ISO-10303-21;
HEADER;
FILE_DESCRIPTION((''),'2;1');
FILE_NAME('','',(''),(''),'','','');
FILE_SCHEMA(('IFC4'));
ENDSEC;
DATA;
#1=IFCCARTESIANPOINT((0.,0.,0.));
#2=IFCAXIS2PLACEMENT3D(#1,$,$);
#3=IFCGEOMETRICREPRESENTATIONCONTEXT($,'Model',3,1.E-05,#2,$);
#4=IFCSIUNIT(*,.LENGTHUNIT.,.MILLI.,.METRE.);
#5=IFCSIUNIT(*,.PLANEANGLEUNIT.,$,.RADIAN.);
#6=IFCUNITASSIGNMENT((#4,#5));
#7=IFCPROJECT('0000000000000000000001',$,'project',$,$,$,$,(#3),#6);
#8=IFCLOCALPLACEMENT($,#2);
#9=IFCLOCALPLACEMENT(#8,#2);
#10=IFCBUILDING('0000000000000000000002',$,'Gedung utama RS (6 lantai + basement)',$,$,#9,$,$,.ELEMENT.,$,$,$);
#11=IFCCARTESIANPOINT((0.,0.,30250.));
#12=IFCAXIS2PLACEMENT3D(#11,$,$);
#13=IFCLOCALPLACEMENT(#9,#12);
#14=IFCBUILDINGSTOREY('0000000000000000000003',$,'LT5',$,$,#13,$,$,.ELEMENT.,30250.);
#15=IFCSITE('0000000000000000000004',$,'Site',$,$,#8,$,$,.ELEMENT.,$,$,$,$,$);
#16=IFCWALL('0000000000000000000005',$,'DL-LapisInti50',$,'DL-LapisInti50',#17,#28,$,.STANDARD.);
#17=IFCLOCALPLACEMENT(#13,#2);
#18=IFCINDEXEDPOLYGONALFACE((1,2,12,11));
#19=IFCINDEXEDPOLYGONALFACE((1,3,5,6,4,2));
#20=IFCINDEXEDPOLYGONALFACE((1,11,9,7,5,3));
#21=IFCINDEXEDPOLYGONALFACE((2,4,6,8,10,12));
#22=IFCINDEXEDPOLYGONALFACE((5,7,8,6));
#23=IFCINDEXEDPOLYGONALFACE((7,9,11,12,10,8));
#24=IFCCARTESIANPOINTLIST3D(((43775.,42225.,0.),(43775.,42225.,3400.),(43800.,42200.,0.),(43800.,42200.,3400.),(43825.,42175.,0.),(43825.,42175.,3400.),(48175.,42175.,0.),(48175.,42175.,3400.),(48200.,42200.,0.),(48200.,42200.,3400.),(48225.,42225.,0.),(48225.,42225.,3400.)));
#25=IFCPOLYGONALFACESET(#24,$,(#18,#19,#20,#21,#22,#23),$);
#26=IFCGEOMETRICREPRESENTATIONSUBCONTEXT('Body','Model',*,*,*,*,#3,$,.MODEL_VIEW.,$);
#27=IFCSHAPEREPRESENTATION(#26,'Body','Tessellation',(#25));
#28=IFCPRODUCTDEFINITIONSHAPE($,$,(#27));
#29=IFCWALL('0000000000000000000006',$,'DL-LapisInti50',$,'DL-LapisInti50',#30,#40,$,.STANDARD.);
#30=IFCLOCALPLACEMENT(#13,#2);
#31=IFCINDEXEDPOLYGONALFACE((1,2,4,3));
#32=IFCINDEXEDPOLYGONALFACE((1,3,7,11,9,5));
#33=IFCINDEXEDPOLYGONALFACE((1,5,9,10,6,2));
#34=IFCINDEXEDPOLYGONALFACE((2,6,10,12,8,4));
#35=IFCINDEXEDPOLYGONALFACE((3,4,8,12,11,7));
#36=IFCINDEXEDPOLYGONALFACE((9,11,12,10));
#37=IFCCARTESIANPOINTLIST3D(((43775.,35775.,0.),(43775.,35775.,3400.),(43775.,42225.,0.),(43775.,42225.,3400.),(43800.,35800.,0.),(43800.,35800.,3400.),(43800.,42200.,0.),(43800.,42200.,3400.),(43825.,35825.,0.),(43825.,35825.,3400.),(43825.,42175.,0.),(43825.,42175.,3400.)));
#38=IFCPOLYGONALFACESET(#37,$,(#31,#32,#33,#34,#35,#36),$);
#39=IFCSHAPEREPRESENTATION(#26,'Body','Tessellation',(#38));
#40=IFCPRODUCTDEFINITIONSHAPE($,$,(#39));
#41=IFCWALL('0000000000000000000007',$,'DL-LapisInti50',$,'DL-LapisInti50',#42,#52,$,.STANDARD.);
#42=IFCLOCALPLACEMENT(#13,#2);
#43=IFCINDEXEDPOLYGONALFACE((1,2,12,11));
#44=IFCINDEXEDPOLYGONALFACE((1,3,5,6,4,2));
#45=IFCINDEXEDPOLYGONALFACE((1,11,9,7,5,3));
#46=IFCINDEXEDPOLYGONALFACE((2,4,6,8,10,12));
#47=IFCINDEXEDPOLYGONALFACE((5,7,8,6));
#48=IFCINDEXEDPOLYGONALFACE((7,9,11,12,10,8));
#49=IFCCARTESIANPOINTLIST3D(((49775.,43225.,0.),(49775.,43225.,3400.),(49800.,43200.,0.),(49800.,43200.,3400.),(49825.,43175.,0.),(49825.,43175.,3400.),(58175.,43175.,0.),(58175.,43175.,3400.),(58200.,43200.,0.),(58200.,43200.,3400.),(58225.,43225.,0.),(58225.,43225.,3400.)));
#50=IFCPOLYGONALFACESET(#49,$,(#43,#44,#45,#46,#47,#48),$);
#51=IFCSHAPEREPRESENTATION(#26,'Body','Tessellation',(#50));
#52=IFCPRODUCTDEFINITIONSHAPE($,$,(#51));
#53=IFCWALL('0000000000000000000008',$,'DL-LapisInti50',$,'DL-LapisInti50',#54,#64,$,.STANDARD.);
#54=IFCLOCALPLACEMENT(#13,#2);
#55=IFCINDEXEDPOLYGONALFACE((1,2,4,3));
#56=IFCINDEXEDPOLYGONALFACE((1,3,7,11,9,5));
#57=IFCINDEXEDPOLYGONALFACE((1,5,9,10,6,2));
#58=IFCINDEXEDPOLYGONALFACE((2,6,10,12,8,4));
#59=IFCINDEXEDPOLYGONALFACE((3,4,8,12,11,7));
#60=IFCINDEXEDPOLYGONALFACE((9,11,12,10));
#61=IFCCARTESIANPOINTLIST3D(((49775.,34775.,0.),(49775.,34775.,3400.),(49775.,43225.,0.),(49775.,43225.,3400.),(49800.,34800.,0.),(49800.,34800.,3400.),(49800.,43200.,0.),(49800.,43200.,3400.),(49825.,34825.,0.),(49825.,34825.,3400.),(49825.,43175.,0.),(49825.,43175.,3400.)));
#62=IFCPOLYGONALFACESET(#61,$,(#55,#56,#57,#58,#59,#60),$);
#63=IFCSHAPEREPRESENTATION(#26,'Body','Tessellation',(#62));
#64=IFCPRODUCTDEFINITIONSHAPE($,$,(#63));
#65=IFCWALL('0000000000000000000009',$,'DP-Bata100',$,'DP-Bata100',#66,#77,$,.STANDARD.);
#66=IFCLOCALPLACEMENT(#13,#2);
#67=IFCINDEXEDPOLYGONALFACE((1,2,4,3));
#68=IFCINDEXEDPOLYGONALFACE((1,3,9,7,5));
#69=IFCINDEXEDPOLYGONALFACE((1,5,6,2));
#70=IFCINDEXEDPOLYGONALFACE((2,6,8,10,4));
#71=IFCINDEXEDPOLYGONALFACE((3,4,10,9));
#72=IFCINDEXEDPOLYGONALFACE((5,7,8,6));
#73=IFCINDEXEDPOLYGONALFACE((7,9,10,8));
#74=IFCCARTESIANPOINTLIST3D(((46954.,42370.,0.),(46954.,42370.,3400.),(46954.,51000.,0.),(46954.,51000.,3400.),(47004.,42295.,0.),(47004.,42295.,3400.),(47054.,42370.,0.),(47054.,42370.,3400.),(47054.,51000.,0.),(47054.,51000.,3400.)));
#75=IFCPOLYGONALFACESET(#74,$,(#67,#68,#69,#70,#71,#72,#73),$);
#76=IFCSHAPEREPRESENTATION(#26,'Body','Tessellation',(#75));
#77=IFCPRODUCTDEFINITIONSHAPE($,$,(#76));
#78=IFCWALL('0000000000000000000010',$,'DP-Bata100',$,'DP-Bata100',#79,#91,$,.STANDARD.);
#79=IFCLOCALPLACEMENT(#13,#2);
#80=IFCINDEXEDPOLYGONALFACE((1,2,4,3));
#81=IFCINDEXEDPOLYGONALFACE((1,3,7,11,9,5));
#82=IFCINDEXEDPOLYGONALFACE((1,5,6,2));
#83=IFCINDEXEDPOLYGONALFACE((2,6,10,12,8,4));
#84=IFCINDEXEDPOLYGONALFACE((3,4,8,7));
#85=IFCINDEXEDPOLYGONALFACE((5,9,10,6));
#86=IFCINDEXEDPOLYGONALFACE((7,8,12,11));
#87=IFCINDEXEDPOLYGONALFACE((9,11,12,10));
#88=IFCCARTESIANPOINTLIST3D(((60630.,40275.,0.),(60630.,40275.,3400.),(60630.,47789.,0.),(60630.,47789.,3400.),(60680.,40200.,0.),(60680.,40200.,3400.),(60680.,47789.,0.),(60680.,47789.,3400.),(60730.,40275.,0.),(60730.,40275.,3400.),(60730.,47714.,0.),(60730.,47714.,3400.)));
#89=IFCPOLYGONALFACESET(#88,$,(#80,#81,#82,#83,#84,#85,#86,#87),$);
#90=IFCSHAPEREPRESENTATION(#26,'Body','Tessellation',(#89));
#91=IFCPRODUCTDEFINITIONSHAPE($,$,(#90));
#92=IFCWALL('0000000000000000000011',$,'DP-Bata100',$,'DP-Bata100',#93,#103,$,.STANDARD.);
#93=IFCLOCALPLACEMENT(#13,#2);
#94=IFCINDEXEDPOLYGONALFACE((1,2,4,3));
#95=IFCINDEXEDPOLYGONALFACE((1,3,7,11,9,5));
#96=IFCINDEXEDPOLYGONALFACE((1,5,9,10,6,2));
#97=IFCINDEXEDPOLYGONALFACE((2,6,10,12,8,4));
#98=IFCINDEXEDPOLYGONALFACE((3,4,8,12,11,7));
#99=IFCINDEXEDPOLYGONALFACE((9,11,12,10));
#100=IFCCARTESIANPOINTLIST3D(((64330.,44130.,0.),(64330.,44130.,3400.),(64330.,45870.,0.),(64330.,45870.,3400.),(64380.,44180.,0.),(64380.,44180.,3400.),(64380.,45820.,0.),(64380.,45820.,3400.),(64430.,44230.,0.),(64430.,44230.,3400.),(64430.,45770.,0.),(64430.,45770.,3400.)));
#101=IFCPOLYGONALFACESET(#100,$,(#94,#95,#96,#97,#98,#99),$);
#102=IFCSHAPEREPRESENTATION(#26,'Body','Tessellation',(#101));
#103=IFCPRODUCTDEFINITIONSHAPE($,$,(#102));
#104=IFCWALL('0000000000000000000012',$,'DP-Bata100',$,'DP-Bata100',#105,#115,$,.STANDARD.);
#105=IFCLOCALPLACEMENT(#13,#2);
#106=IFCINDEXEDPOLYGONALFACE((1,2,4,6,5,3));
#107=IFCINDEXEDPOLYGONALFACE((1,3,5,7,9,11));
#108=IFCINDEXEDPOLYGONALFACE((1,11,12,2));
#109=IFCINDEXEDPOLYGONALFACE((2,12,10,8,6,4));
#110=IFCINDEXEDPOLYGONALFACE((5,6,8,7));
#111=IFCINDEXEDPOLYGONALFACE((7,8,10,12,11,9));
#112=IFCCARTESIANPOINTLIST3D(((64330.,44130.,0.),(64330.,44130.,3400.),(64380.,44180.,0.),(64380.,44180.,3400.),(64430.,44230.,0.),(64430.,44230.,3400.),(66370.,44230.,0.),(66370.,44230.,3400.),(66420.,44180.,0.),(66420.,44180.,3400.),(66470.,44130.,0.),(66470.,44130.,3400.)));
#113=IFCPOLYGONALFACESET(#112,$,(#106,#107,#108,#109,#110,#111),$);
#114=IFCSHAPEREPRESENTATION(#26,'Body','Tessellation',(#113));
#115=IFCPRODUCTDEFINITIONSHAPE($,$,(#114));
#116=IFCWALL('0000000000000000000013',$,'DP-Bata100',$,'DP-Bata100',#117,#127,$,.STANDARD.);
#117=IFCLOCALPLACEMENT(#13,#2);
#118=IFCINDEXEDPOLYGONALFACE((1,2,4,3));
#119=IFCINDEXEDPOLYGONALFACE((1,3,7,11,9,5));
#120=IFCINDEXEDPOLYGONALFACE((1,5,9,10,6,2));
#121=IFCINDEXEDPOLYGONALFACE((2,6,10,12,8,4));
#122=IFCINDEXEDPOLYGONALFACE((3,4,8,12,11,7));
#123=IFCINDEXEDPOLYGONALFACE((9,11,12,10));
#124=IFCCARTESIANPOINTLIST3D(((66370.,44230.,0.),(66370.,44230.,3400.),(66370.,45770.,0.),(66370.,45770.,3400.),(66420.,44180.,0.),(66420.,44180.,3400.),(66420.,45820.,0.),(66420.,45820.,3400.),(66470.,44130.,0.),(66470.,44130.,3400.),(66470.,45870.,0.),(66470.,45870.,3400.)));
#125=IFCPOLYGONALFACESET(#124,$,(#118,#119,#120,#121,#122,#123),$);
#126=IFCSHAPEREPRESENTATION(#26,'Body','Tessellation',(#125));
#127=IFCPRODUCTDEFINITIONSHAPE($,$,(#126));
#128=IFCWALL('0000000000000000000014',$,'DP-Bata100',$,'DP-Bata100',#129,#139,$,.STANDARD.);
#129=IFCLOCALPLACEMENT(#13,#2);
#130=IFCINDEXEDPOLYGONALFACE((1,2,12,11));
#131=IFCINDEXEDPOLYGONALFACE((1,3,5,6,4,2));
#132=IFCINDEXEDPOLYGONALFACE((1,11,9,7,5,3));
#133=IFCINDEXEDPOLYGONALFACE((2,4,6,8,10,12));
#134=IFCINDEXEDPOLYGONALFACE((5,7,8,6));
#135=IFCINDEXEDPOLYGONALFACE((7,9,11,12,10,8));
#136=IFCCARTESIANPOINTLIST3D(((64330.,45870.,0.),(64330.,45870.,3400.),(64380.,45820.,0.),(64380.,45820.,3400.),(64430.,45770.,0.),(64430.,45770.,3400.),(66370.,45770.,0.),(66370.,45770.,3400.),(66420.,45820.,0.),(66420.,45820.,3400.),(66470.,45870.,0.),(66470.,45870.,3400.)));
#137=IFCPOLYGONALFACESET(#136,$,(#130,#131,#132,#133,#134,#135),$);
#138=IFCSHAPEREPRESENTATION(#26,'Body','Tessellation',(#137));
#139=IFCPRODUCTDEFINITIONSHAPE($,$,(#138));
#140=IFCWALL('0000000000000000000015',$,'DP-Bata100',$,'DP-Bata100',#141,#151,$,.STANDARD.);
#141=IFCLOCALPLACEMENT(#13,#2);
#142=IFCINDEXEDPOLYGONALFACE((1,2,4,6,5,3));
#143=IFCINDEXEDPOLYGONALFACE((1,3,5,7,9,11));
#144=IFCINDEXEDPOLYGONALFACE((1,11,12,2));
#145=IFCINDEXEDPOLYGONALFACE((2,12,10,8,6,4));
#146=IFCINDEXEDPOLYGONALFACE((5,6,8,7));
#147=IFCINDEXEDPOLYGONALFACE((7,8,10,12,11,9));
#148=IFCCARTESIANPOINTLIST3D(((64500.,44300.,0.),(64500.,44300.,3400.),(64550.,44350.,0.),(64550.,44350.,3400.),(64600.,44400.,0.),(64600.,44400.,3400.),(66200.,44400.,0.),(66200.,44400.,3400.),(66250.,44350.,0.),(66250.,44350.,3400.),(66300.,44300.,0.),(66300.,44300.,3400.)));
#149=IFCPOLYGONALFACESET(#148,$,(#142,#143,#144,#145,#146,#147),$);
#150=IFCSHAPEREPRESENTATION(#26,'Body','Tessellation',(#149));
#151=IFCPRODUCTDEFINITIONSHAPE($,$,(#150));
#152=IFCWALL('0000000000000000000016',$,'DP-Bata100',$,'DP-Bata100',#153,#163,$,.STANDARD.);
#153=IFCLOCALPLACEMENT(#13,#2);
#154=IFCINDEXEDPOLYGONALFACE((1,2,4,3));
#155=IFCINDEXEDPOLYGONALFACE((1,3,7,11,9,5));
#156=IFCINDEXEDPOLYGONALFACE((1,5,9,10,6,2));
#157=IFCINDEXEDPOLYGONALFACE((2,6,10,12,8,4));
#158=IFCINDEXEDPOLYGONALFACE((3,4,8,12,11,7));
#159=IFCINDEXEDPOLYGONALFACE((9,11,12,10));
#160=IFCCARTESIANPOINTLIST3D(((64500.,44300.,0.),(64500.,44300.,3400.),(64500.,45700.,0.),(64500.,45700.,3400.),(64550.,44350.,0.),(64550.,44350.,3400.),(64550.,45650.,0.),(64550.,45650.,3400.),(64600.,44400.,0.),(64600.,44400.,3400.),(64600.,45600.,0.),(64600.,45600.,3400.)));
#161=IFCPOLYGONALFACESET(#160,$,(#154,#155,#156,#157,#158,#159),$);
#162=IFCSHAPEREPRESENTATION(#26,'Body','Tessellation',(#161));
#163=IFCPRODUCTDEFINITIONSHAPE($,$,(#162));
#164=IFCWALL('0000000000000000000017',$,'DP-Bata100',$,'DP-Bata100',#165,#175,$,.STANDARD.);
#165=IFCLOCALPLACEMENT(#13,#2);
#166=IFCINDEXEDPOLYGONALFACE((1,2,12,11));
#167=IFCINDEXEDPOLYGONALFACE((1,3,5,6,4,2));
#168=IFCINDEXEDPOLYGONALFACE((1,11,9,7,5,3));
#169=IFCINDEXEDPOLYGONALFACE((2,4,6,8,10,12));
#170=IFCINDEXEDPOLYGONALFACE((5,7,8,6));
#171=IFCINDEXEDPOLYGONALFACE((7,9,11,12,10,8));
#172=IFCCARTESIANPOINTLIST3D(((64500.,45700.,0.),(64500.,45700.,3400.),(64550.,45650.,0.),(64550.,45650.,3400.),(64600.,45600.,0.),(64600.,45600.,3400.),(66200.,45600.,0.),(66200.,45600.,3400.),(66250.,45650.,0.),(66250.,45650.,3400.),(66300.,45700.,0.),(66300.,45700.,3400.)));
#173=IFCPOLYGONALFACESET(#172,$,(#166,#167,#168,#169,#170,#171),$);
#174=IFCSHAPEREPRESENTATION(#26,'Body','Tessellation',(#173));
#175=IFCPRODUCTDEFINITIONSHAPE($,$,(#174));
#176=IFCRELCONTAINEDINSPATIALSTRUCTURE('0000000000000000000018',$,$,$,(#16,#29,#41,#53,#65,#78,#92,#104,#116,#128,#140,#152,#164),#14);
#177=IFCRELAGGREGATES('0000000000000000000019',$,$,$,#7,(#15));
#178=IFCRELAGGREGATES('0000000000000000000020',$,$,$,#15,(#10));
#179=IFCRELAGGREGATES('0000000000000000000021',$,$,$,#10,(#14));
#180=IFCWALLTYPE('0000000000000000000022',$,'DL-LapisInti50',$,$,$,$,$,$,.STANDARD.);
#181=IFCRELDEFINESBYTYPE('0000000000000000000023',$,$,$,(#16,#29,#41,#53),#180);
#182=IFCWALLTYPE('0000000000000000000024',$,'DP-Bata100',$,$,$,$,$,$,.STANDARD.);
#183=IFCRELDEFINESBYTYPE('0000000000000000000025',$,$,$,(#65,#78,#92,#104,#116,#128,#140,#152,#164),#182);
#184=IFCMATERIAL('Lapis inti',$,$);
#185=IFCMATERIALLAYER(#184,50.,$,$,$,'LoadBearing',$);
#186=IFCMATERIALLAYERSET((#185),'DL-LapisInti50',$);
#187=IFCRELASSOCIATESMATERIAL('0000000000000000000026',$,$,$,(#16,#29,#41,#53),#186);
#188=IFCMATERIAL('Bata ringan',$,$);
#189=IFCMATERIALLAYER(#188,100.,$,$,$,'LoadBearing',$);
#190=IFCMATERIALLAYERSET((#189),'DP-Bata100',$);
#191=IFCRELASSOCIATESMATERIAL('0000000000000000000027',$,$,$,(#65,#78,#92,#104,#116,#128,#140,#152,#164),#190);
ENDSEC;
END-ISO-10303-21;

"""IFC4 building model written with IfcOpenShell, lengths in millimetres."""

from ifc_helpers import new_model, si_unit, frame, origin, place, context, subcontext, project, spatial, polyline, outline, extrude, material, layer, layer_set, layer_usage, type_object, element, save


model = new_model("IFC4")

# Units and contexts
model_context = context("Model", 3, precision=1e-05, world=origin())
body_context = subcontext(model_context, "Body", "Model", "MODEL_VIEW")
ifc_project = project(units=[si_unit("LENGTHUNIT", "METRE", prefix="MILLI"), si_unit("PLANEANGLEUNIT", "RADIAN")], contexts=[model_context])

# Site, building, storey
site_placement = place(None, origin())
site = spatial("IfcSite", under=ifc_project, at=site_placement, Name="Site", CompositionType="ELEMENT")
building_placement = place(site_placement, origin())
building = spatial("IfcBuilding", under=site, at=building_placement, Name="Gedung utama RS (6 lantai + basement)", CompositionType="ELEMENT")
storey_placement = place(building_placement, frame((0.0, 0.0, 30250.0)))
storey = spatial("IfcBuildingStorey", under=building, at=storey_placement, Name="LT5", CompositionType="ELEMENT", Elevation=30250.0)

# Walls
ifc_material_1 = material(Name="Lapis inti")
ifc_layer_1 = layer(ifc_material_1, 50.0, Category="LoadBearing")
ifc_layer_set_1 = layer_set([ifc_layer_1], Name="DL-LapisInti50")
ifc_layer_usage_1 = layer_usage(ifc_layer_set_1, "AXIS2", "NEGATIVE", 25.0)
wall_type_1 = type_object("IfcWallType", Name="DL-LapisInti50", PredefinedType="STANDARD")
wall_1_placement = place(storey_placement, frame((48200.0, 42200.0, 0.0), z_axis=(0.0, 0.0, 1.0), x_axis=(-1.0, 0.0, 0.0)))
element("IfcWall", 1, at=wall_1_placement, inside=storey, type_object=wall_type_1, material=ifc_layer_usage_1, Name="DL-LapisInti50", ObjectType="DL-LapisInti50", PredefinedType="STANDARD", context=body_context, shape_type="SweptSolid", body=[
    extrude(outline(polyline([(-25.0, -25.0), (0.0, 0.0), (25.0, 25.0), (4375.0, 25.0), (4400.0, 0.0), (4425.0, -25.0), (-25.0, -25.0)])), origin(), (0.0, 0.0, 1.0), 3400.0),
])
wall_2_placement = place(storey_placement, frame((43800.0, 42200.0, 0.0), z_axis=(0.0, 0.0, 1.0), x_axis=(0.0, -1.0, 0.0)))
element("IfcWall", 2, at=wall_2_placement, inside=storey, type_object=wall_type_1, material=ifc_layer_usage_1, Name="DL-LapisInti50", ObjectType="DL-LapisInti50", PredefinedType="STANDARD", context=body_context, shape_type="SweptSolid", body=[
    extrude(outline(polyline([(-25.0, -25.0), (0.0, 0.0), (25.0, 25.0), (6375.0, 25.0), (6400.0, 0.0), (6425.0, -25.0), (-25.0, -25.0)])), origin(), (0.0, 0.0, 1.0), 3400.0),
])
for number, where, z_axis, x_axis, name in (
    (3, (58200.0, 43200.0, 0.0), (0.0, 0.0, 1.0), (-1.0, 0.0, 0.0), "DL-LapisInti50"),
    (4, (49800.0, 43200.0, 0.0), (0.0, 0.0, 1.0), (0.0, -1.0, 0.0), "DL-LapisInti50"),
):
    element("IfcWall", number, at=place(storey_placement, frame(where, z_axis=z_axis, x_axis=x_axis)), inside=storey, type_object=wall_type_1, material=ifc_layer_usage_1, Name=name, ObjectType="DL-LapisInti50", PredefinedType="STANDARD", context=body_context, shape_type="SweptSolid", body=[
        extrude(outline(polyline([(-25.0, -25.0), (0.0, 0.0), (25.0, 25.0), (8375.0, 25.0), (8400.0, 0.0), (8425.0, -25.0), (-25.0, -25.0)])), origin(), (0.0, 0.0, 1.0), 3400.0),
    ])
ifc_material_2 = material(Name="Bata ringan")
ifc_layer_2 = layer(ifc_material_2, 100.0, Category="LoadBearing")
ifc_layer_set_2 = layer_set([ifc_layer_2], Name="DP-Bata100")
ifc_layer_usage_2 = layer_usage(ifc_layer_set_2, "AXIS2", "NEGATIVE", 50.0)
wall_type_2 = type_object("IfcWallType", Name="DP-Bata100", PredefinedType="STANDARD")
wall_3_placement = place(storey_placement, frame((47004.0, 51000.0, 0.0), z_axis=(0.0, 0.0, 1.0), x_axis=(0.0, -1.0, 0.0)))
element("IfcWall", 5, at=wall_3_placement, inside=storey, type_object=wall_type_2, material=ifc_layer_usage_2, Name="DP-Bata100", ObjectType="DP-Bata100", PredefinedType="STANDARD", context=body_context, shape_type="SweptSolid", body=[
    extrude(outline(polyline([(0.0, -50.0), (0.0, 50.0), (8630.0, 50.0), (8705.0, 0.0), (8630.0, -50.0), (0.0, -50.0)])), origin(), (0.0, 0.0, 1.0), 3400.0),
])
wall_4_placement = place(storey_placement, frame((60680.0, 47789.0, 0.0), z_axis=(0.0, 0.0, 1.0), x_axis=(0.0, -1.0, 0.0)))
element("IfcWall", 6, at=wall_4_placement, inside=storey, type_object=wall_type_2, material=ifc_layer_usage_2, Name="DP-Bata100", ObjectType="DP-Bata100", PredefinedType="STANDARD", context=body_context, shape_type="SweptSolid", body=[
    extrude(outline(polyline([(0.0, -50.0), (0.0, 0.0), (75.0, 50.0), (7514.0, 50.0), (7589.0, 0.0), (7514.0, -50.0), (0.0, -50.0)])), origin(), (0.0, 0.0, 1.0), 3400.0),
])
wall_5_placement = place(storey_placement, frame((64380.0, 45820.0, 0.0), z_axis=(0.0, 0.0, 1.0), x_axis=(0.0, -1.0, 0.0)))
element("IfcWall", 7, at=wall_5_placement, inside=storey, type_object=wall_type_2, material=ifc_layer_usage_2, Name="DP-Bata100", ObjectType="DP-Bata100", PredefinedType="STANDARD", context=body_context, shape_type="SweptSolid", body=[
    extrude(outline(polyline([(-50.0, -50.0), (0.0, 0.0), (50.0, 50.0), (1590.0, 50.0), (1640.0, 0.0), (1690.0, -50.0), (-50.0, -50.0)])), origin(), (0.0, 0.0, 1.0), 3400.0),
])
wall_6_placement = place(storey_placement, frame((64380.0, 44180.0, 0.0), z_axis=(0.0, 0.0, 1.0), x_axis=(1.0, 0.0, 0.0)))
element("IfcWall", 8, at=wall_6_placement, inside=storey, type_object=wall_type_2, material=ifc_layer_usage_2, Name="DP-Bata100", ObjectType="DP-Bata100", PredefinedType="STANDARD", context=body_context, shape_type="SweptSolid", body=[
    extrude(outline(polyline([(-50.0, -50.0), (0.0, 0.0), (50.0, 50.0), (1990.0, 50.0), (2040.0, 0.0), (2090.0, -50.0), (-50.0, -50.0)])), origin(), (0.0, 0.0, 1.0), 3400.0),
])
wall_7_placement = place(storey_placement, frame((66420.0, 44180.0, 0.0), z_axis=(0.0, 0.0, 1.0), x_axis=(0.0, 1.0, 0.0)))
element("IfcWall", 9, at=wall_7_placement, inside=storey, type_object=wall_type_2, material=ifc_layer_usage_2, Name="DP-Bata100", ObjectType="DP-Bata100", PredefinedType="STANDARD", context=body_context, shape_type="SweptSolid", body=[
    extrude(outline(polyline([(-50.0, -50.0), (0.0, 0.0), (50.0, 50.0), (1590.0, 50.0), (1640.0, 0.0), (1690.0, -50.0), (-50.0, -50.0)])), origin(), (0.0, 0.0, 1.0), 3400.0),
])
wall_8_placement = place(storey_placement, frame((66420.0, 45820.0, 0.0), z_axis=(0.0, 0.0, 1.0), x_axis=(-1.0, 0.0, 0.0)))
element("IfcWall", 10, at=wall_8_placement, inside=storey, type_object=wall_type_2, material=ifc_layer_usage_2, Name="DP-Bata100", ObjectType="DP-Bata100", PredefinedType="STANDARD", context=body_context, shape_type="SweptSolid", body=[
    extrude(outline(polyline([(-50.0, -50.0), (0.0, 0.0), (50.0, 50.0), (1990.0, 50.0), (2040.0, 0.0), (2090.0, -50.0), (-50.0, -50.0)])), origin(), (0.0, 0.0, 1.0), 3400.0),
])
wall_9_placement = place(storey_placement, frame((66250.0, 44350.0, 0.0), z_axis=(0.0, 0.0, 1.0), x_axis=(-1.0, 0.0, 0.0)))
element("IfcWall", 11, at=wall_9_placement, inside=storey, type_object=wall_type_2, material=ifc_layer_usage_2, Name="DP-Bata100", ObjectType="DP-Bata100", PredefinedType="STANDARD", context=body_context, shape_type="SweptSolid", body=[
    extrude(outline(polyline([(50.0, -50.0), (0.0, 0.0), (-50.0, 50.0), (1750.0, 50.0), (1700.0, 0.0), (1650.0, -50.0), (50.0, -50.0)])), origin(), (0.0, 0.0, 1.0), 3400.0),
])
wall_10_placement = place(storey_placement, frame((64550.0, 44350.0, 0.0), z_axis=(0.0, 0.0, 1.0), x_axis=(0.0, 1.0, 0.0)))
element("IfcWall", 12, at=wall_10_placement, inside=storey, type_object=wall_type_2, material=ifc_layer_usage_2, Name="DP-Bata100", ObjectType="DP-Bata100", PredefinedType="STANDARD", context=body_context, shape_type="SweptSolid", body=[
    extrude(outline(polyline([(50.0, -50.0), (0.0, 0.0), (-50.0, 50.0), (1350.0, 50.0), (1300.0, 0.0), (1250.0, -50.0), (50.0, -50.0)])), origin(), (0.0, 0.0, 1.0), 3400.0),
])
wall_11_placement = place(storey_placement, frame((64550.0, 45650.0, 0.0), z_axis=(0.0, 0.0, 1.0), x_axis=(1.0, 0.0, 0.0)))
element("IfcWall", 13, at=wall_11_placement, inside=storey, type_object=wall_type_2, material=ifc_layer_usage_2, Name="DP-Bata100", ObjectType="DP-Bata100", PredefinedType="STANDARD", context=body_context, shape_type="SweptSolid", body=[
    extrude(outline(polyline([(50.0, -50.0), (0.0, 0.0), (-50.0, 50.0), (1750.0, 50.0), (1700.0, 0.0), (1650.0, -50.0), (50.0, -50.0)])), origin(), (0.0, 0.0, 1.0), 3400.0),
])

save(model, "model.ifc")
